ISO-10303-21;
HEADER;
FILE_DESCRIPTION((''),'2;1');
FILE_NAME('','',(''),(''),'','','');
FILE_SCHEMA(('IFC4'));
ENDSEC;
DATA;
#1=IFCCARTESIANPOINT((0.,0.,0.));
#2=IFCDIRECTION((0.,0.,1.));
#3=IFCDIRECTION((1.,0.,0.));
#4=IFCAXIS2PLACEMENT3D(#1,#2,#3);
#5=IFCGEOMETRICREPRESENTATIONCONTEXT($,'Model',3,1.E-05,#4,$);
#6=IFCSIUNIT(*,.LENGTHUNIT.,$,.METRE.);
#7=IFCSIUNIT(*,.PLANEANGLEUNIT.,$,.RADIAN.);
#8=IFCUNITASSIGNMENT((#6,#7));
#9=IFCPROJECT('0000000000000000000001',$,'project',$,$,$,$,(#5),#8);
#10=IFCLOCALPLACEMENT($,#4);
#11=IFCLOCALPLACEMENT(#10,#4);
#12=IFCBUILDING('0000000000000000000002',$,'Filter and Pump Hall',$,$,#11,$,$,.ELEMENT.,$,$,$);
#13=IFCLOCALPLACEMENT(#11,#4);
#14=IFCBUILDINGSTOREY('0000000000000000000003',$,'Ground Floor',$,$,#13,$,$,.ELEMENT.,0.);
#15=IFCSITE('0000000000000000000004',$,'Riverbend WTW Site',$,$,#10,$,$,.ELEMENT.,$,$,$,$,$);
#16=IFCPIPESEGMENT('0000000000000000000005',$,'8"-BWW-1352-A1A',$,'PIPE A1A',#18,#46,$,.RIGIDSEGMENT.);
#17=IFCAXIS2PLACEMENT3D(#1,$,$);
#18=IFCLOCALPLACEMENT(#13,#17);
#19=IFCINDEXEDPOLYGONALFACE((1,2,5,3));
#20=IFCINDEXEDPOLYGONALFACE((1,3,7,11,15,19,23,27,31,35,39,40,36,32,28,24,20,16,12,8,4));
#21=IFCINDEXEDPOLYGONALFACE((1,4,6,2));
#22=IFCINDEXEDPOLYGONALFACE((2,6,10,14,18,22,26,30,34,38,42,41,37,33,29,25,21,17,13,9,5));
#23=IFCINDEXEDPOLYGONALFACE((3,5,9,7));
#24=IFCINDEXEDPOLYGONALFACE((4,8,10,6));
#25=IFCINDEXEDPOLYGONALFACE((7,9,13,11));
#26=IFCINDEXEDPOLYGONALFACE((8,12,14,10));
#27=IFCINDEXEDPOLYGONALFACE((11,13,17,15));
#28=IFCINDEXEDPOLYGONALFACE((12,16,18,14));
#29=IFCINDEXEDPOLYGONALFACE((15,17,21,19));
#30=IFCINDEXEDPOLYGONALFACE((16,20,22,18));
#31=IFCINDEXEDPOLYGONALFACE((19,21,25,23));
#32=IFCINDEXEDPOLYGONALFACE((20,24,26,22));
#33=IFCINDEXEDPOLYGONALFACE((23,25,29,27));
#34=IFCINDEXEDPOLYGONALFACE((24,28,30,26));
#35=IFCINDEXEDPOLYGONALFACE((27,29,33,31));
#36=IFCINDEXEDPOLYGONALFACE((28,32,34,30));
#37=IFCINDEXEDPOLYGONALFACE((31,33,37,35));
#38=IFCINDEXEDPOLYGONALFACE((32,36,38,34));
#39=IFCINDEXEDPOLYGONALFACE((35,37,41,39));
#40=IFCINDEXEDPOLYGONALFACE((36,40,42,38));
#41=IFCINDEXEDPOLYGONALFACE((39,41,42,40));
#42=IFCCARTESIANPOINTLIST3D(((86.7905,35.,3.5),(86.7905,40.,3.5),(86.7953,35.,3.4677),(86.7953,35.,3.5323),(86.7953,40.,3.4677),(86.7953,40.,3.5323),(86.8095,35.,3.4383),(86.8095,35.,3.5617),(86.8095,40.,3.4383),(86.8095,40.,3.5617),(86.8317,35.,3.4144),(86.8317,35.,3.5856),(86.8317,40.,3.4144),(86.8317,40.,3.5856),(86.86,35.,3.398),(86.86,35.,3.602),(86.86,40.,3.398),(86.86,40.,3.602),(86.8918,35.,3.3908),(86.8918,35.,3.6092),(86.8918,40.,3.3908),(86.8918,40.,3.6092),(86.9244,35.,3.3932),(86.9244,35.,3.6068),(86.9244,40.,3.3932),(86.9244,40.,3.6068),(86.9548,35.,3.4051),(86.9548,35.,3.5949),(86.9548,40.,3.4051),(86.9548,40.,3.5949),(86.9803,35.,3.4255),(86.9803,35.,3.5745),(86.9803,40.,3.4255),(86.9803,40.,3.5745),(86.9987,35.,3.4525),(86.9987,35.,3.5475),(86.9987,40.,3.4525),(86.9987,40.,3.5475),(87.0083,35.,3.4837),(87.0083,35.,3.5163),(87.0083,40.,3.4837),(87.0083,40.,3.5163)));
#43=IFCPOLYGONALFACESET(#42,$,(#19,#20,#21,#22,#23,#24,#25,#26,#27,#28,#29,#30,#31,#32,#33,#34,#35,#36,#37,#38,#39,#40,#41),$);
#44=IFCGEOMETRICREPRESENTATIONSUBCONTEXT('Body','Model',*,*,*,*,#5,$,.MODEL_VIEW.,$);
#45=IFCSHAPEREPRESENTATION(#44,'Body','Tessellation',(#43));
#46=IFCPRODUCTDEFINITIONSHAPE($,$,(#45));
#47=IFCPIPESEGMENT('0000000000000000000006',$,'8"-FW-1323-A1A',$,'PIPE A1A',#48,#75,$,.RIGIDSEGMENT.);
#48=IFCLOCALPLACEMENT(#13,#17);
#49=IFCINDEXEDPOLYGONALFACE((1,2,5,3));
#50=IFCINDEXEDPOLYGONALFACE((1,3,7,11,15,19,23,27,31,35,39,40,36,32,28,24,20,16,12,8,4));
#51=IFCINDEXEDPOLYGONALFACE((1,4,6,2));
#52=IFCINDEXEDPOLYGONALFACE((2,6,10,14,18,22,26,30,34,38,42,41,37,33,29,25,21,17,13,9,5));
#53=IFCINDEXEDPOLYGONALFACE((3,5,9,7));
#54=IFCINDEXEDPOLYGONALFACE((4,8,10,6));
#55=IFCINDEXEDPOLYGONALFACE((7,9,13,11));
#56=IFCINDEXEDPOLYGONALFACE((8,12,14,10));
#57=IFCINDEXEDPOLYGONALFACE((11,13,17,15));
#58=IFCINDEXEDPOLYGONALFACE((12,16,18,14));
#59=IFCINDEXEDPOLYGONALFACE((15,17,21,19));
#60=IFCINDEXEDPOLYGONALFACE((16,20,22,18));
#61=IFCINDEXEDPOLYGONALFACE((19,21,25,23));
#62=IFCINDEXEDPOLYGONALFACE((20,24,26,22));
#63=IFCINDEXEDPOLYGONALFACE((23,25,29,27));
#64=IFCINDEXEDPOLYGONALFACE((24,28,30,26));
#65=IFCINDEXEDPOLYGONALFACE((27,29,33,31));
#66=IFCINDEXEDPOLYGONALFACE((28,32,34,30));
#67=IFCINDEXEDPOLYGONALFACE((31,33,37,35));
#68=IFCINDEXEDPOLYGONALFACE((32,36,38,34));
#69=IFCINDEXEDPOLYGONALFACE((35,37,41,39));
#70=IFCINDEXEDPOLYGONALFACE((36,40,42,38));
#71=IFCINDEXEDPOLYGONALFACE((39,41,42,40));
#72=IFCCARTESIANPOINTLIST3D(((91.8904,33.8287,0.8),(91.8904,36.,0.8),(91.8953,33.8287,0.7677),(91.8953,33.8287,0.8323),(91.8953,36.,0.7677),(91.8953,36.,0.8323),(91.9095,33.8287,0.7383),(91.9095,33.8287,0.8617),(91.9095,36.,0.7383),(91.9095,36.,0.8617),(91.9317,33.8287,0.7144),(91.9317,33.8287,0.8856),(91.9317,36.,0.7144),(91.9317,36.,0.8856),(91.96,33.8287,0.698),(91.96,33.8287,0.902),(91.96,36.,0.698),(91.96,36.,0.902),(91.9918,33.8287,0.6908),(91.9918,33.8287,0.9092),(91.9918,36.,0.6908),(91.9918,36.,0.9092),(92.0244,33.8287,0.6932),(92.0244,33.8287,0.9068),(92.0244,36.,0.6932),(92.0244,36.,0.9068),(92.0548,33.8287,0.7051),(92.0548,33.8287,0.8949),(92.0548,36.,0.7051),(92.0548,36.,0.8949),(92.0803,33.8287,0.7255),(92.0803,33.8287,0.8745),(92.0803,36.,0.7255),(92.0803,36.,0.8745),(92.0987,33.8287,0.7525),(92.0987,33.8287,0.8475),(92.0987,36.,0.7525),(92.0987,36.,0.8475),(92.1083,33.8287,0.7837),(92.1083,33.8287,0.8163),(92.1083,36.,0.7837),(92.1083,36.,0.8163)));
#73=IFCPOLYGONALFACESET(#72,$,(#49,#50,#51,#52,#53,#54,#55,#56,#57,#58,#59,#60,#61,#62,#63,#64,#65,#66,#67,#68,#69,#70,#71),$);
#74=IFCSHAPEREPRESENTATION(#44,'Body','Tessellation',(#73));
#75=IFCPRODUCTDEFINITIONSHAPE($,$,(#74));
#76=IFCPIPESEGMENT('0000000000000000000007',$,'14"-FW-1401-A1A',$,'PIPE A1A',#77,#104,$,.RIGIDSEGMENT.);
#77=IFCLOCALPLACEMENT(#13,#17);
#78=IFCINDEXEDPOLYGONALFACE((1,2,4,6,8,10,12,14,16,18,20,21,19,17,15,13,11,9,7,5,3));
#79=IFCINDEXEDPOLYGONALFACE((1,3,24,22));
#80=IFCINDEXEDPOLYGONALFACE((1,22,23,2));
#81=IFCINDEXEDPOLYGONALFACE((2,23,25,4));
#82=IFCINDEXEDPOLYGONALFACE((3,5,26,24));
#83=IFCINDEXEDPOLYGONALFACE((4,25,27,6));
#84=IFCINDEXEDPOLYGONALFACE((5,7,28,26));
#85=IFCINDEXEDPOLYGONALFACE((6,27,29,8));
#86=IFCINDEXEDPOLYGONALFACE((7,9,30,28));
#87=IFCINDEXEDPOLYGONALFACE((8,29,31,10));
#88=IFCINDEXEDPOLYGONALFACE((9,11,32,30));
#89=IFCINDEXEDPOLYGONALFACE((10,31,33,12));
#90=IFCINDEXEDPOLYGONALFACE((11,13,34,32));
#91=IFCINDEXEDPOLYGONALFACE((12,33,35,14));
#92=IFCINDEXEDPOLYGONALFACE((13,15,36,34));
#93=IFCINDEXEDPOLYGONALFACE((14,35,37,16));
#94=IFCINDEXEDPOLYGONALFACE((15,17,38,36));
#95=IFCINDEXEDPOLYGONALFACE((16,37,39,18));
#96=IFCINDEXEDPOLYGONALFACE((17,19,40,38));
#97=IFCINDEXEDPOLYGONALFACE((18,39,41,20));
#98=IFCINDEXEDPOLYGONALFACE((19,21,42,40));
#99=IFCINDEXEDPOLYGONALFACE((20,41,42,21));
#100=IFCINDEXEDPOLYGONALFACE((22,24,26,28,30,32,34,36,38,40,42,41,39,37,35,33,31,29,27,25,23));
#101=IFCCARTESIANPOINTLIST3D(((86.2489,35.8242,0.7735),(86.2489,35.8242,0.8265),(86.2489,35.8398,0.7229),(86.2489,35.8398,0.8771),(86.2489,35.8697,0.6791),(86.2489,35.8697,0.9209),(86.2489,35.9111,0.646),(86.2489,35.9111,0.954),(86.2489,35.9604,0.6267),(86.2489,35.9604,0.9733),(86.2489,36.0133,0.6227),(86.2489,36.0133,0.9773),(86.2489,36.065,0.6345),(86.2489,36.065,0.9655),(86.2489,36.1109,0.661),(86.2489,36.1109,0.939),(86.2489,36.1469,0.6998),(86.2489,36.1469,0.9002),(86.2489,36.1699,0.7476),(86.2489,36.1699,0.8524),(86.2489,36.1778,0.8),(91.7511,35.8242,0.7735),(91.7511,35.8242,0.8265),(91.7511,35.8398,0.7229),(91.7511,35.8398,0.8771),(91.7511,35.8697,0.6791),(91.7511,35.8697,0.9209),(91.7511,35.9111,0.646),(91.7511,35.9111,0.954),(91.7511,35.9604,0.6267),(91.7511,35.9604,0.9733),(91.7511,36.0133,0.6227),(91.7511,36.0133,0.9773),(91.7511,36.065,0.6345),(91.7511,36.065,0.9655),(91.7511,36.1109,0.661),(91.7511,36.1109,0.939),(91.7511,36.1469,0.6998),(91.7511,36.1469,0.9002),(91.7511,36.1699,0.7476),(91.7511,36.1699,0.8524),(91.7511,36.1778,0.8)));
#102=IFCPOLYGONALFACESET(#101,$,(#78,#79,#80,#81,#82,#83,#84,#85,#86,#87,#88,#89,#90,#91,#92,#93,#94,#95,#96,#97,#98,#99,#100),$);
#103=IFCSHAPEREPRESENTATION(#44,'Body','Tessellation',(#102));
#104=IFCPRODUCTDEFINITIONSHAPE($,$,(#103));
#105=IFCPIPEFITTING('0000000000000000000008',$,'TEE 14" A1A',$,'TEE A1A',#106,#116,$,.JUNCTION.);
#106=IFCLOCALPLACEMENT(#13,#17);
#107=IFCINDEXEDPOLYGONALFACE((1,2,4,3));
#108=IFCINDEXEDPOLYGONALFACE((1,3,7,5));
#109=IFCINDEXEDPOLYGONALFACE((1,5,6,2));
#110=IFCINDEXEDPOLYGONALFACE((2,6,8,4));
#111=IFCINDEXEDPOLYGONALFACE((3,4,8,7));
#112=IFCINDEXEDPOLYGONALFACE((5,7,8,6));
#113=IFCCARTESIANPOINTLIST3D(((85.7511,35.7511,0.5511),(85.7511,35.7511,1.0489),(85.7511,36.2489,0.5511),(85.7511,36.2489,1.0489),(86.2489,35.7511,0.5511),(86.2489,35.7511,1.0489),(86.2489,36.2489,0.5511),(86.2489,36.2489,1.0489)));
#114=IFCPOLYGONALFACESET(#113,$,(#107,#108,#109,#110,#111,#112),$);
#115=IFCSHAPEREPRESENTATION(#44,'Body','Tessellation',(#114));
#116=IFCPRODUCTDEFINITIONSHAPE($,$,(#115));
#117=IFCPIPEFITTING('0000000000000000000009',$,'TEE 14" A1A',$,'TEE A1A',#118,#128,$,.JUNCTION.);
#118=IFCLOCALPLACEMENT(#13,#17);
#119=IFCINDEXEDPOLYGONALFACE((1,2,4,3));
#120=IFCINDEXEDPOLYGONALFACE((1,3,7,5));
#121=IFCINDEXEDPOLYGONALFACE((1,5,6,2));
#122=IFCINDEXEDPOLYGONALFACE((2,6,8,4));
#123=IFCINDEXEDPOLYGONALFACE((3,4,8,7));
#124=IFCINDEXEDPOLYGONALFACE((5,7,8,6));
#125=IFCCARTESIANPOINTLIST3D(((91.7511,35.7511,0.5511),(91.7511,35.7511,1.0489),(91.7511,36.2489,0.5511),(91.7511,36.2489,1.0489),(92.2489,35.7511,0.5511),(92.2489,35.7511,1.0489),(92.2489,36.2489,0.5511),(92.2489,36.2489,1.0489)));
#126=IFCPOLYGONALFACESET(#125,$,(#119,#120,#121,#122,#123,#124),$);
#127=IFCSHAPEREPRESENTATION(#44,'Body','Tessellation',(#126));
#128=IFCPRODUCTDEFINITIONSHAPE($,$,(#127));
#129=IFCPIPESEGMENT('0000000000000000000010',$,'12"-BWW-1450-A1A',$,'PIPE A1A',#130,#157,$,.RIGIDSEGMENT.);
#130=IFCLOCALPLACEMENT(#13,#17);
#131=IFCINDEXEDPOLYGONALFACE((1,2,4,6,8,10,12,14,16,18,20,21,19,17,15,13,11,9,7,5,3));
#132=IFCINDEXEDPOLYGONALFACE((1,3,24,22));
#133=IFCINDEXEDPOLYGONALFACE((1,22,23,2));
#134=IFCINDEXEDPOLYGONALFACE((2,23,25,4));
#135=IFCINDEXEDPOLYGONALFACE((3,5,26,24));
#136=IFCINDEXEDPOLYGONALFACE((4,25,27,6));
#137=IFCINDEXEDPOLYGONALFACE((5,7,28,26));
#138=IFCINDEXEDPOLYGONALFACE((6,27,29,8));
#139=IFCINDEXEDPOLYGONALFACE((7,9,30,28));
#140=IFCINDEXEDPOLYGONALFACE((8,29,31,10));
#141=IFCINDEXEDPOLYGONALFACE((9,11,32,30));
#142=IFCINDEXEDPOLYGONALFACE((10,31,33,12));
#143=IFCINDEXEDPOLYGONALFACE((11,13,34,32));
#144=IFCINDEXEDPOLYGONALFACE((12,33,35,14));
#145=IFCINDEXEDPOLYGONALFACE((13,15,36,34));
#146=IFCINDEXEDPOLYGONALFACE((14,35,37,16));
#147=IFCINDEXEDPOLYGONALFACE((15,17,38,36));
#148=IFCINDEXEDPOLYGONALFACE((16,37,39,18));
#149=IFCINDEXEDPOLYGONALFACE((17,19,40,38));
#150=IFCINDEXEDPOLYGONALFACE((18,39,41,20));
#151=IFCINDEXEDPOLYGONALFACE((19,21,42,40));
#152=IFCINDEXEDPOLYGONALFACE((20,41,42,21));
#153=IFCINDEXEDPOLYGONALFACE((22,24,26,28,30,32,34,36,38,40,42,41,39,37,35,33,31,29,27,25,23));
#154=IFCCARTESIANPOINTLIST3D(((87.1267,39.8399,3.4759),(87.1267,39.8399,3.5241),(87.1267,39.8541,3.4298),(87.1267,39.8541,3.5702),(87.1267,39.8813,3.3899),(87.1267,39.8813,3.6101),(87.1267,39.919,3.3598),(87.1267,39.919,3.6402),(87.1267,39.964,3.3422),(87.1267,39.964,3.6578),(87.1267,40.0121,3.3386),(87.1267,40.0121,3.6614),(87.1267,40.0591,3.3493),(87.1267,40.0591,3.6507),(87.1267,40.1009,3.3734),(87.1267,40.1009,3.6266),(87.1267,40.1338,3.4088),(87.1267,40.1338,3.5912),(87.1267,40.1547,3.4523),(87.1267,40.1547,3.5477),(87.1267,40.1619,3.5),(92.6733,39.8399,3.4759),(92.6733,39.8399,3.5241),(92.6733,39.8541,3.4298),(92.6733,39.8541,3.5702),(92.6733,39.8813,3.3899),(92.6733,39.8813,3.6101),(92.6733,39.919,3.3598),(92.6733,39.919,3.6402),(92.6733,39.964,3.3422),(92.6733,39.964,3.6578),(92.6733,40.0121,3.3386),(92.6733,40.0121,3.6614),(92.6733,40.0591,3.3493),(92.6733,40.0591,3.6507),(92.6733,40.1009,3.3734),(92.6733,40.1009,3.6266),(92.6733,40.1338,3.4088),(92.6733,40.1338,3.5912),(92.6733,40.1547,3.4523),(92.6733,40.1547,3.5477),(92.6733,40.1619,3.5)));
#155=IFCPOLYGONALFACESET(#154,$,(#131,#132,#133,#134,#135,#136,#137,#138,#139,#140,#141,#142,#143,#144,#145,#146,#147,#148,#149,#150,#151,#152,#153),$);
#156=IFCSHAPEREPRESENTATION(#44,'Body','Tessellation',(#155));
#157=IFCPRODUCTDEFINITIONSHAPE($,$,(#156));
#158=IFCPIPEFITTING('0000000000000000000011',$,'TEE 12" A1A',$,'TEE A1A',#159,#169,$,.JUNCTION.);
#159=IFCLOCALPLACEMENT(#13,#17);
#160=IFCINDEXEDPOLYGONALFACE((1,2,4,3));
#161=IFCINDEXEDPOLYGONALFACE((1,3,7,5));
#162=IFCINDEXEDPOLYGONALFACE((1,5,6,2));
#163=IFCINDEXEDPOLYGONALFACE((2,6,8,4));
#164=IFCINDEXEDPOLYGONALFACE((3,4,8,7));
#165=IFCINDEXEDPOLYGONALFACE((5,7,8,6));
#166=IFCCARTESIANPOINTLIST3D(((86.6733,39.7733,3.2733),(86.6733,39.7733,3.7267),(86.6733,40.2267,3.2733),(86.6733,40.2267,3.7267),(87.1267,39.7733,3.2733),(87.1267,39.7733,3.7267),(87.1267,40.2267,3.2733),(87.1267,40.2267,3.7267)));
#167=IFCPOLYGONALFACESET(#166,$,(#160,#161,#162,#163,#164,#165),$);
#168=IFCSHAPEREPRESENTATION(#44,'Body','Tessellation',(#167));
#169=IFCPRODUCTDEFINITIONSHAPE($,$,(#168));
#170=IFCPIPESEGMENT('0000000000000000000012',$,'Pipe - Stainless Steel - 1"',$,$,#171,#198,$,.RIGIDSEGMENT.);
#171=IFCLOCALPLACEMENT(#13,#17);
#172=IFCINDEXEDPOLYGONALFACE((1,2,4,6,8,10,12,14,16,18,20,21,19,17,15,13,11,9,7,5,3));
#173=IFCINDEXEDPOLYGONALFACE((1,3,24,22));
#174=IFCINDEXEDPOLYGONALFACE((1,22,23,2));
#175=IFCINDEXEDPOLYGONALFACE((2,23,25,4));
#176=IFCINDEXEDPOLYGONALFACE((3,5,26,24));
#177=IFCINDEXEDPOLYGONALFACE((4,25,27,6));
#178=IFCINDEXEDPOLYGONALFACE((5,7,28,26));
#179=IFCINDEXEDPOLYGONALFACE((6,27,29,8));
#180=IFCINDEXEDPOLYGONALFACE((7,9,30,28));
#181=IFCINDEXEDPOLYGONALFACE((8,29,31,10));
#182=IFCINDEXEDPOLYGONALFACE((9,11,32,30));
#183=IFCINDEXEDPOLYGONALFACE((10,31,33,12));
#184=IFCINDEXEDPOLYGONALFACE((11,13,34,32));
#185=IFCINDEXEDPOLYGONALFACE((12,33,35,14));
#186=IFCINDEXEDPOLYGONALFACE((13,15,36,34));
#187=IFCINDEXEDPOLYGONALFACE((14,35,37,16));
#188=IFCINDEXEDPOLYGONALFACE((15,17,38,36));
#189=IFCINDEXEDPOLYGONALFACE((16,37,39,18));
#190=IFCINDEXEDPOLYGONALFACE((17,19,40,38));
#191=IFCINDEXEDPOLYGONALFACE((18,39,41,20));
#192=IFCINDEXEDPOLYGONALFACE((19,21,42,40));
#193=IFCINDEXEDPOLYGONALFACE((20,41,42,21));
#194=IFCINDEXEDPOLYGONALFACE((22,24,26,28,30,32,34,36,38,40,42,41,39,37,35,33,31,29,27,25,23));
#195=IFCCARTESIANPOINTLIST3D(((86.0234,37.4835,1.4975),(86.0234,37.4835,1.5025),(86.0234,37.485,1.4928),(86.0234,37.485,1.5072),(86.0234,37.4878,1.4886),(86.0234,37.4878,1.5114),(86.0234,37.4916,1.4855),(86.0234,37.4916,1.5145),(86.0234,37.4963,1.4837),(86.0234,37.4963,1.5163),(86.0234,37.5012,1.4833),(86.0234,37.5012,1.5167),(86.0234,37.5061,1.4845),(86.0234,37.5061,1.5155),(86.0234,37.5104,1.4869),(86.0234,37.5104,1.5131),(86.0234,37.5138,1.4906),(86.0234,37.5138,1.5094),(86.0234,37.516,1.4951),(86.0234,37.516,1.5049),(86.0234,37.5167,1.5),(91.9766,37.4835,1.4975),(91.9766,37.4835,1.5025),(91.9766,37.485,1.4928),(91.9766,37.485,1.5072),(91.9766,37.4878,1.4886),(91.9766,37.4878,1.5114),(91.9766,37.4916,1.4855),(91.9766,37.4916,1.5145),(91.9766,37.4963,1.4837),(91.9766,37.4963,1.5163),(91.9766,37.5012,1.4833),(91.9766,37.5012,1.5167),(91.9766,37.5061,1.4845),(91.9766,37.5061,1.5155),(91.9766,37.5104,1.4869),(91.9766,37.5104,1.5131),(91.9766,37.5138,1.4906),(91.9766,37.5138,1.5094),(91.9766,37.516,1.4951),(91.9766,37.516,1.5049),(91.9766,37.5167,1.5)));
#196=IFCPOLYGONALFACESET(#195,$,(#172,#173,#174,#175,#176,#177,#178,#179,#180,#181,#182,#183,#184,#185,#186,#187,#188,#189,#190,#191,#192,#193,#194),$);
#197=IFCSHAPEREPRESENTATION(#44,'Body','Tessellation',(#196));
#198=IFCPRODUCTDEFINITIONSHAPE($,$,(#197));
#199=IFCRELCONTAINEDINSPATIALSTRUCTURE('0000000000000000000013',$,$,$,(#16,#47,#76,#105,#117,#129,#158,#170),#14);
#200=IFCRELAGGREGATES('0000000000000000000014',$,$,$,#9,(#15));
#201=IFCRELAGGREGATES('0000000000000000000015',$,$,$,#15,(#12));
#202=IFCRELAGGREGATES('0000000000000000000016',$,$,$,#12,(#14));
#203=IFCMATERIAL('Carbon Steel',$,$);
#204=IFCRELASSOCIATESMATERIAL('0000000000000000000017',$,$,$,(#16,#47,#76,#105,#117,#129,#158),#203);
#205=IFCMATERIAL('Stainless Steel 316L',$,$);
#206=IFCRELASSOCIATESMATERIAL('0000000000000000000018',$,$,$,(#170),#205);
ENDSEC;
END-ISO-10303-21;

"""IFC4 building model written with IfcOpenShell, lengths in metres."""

from ifc_helpers import new_model, si_unit, frame, origin_with_axes, origin_2d, place, context, subcontext, project, spatial, rectangle, circle, extrude, material, element, save


model = new_model("IFC4")

# Units and contexts
model_context = context("Model", 3, precision=1e-05, world=origin_with_axes())
body_context = subcontext(model_context, "Body", "Model", "MODEL_VIEW")
ifc_project = project(units=[si_unit("LENGTHUNIT", "METRE"), si_unit("PLANEANGLEUNIT", "RADIAN")], contexts=[model_context])

# Site, building, storey
site_placement = place(None, origin_with_axes())
site = spatial("IfcSite", under=ifc_project, at=site_placement, Name="Riverbend WTW Site", CompositionType="ELEMENT")
building_placement = place(site_placement, origin_with_axes())
building = spatial("IfcBuilding", under=site, at=building_placement, Name="Filter and Pump Hall", CompositionType="ELEMENT")
storey_placement = place(building_placement, origin_with_axes())
storey = spatial("IfcBuildingStorey", under=building, at=storey_placement, Name="Ground Floor", CompositionType="ELEMENT", Elevation=0.0)

# Pipe segments
ifc_material_1 = material(Name="Carbon Steel")
pipe_segment_1_placement = place(None, frame((86.9, 35.0, 3.5), z_axis=(0.0, 0.0, 1.0), x_axis=(1.0, 0.0, 0.0)))
element("IfcPipeSegment", 1, at=pipe_segment_1_placement, inside=storey, material=ifc_material_1, Name="8\"-BWW-1352-A1A", ObjectType="PIPE A1A", PredefinedType="RIGIDSEGMENT", context=body_context, shape_type="SweptSolid", body=[
    extrude(circle(Radius=0.1095, at=origin_2d()), frame((0.0, 0.0, 0.0), z_axis=(0.0, 1.0, 0.0), x_axis=(-1.0, 0.0, 0.0)), (0.0, 0.0, 1.0), 5.0),
])
pipe_segment_2_placement = place(None, frame((92.0, 33.8287, 0.8), z_axis=(0.0, 0.0, 1.0), x_axis=(1.0, 0.0, 0.0)))
element("IfcPipeSegment", 2, at=pipe_segment_2_placement, inside=storey, material=ifc_material_1, Name="8\"-FW-1323-A1A", ObjectType="PIPE A1A", PredefinedType="RIGIDSEGMENT", context=body_context, shape_type="SweptSolid", body=[
    extrude(circle(Radius=0.1095, at=origin_2d()), frame((0.0, 0.0, 0.0), z_axis=(0.0, 1.0, 0.0), x_axis=(-1.0, 0.0, 0.0)), (0.0, 0.0, 1.0), 2.1713),
])
pipe_segment_3_placement = place(None, frame((86.2489, 36.0, 0.8), z_axis=(0.0, 0.0, 1.0), x_axis=(1.0, 0.0, 0.0)))
element("IfcPipeSegment", 3, at=pipe_segment_3_placement, inside=storey, material=ifc_material_1, Name="14\"-FW-1401-A1A", ObjectType="PIPE A1A", PredefinedType="RIGIDSEGMENT", context=body_context, shape_type="SweptSolid", body=[
    extrude(circle(Radius=0.1778, at=origin_2d()), frame((0.0, 0.0, 0.0), z_axis=(1.0, 0.0, 0.0), x_axis=(0.0, 1.0, 0.0)), (0.0, 0.0, 1.0), 5.5022),
])

# Pipe fittings
for number, where, z_axis, x_axis, name in (
    (4, (86.0, 36.0, 0.8), (0.0, 0.0, 1.0), (1.0, 0.0, 0.0), "TEE 14\" A1A"),
    (5, (92.0, 36.0, 0.8), (0.0, 0.0, 1.0), (1.0, 0.0, 0.0), "TEE 14\" A1A"),
):
    element("IfcPipeFitting", number, at=place(None, frame(where, z_axis=z_axis, x_axis=x_axis)), inside=storey, material=ifc_material_1, Name=name, ObjectType="TEE A1A", PredefinedType="JUNCTION", context=body_context, shape_type="SweptSolid", body=[
        extrude(rectangle(XDim=0.4978, YDim=0.4978, at=origin_2d()), frame((0.0, 0.0, -0.2489), z_axis=(0.0, 0.0, 1.0), x_axis=(1.0, 0.0, 0.0)), (0.0, 0.0, 1.0), 0.4978),
    ])

# Pipe segment
pipe_segment_4_placement = place(None, frame((87.1267, 40.0, 3.5), z_axis=(0.0, 0.0, 1.0), x_axis=(1.0, 0.0, 0.0)))
element("IfcPipeSegment", 6, at=pipe_segment_4_placement, inside=storey, material=ifc_material_1, Name="12\"-BWW-1450-A1A", ObjectType="PIPE A1A", PredefinedType="RIGIDSEGMENT", context=body_context, shape_type="SweptSolid", body=[
    extrude(circle(Radius=0.1619, at=origin_2d()), frame((0.0, 0.0, 0.0), z_axis=(1.0, 0.0, 0.0), x_axis=(0.0, 1.0, 0.0)), (0.0, 0.0, 1.0), 5.5467),
])

# Pipe fitting
pipe_fitting_1_placement = place(None, frame((86.9, 40.0, 3.5), z_axis=(0.0, 0.0, 1.0), x_axis=(1.0, 0.0, 0.0)))
element("IfcPipeFitting", 7, at=pipe_fitting_1_placement, inside=storey, material=ifc_material_1, Name="TEE 12\" A1A", ObjectType="TEE A1A", PredefinedType="JUNCTION", context=body_context, shape_type="SweptSolid", body=[
    extrude(rectangle(XDim=0.4533, YDim=0.4533, at=origin_2d()), frame((0.0, 0.0, -0.2267), z_axis=(0.0, 0.0, 1.0), x_axis=(1.0, 0.0, 0.0)), (0.0, 0.0, 1.0), 0.4533),
])

# Pipe segment
ifc_material_2 = material(Name="Stainless Steel 316L")
pipe_segment_5_placement = place(None, frame((86.0234, 37.5, 1.5), z_axis=(0.0, 0.0, 1.0), x_axis=(1.0, 0.0, 0.0)))
element("IfcPipeSegment", 8, at=pipe_segment_5_placement, inside=storey, material=ifc_material_2, Name="Pipe - Stainless Steel - 1\"", PredefinedType="RIGIDSEGMENT", context=body_context, shape_type="SweptSolid", body=[
    extrude(circle(Radius=0.0167, at=origin_2d()), frame((0.0, 0.0, 0.0), z_axis=(1.0, 0.0, 0.0), x_axis=(0.0, 1.0, 0.0)), (0.0, 0.0, 1.0), 5.9532),
])

save(model, "model.ifc")
